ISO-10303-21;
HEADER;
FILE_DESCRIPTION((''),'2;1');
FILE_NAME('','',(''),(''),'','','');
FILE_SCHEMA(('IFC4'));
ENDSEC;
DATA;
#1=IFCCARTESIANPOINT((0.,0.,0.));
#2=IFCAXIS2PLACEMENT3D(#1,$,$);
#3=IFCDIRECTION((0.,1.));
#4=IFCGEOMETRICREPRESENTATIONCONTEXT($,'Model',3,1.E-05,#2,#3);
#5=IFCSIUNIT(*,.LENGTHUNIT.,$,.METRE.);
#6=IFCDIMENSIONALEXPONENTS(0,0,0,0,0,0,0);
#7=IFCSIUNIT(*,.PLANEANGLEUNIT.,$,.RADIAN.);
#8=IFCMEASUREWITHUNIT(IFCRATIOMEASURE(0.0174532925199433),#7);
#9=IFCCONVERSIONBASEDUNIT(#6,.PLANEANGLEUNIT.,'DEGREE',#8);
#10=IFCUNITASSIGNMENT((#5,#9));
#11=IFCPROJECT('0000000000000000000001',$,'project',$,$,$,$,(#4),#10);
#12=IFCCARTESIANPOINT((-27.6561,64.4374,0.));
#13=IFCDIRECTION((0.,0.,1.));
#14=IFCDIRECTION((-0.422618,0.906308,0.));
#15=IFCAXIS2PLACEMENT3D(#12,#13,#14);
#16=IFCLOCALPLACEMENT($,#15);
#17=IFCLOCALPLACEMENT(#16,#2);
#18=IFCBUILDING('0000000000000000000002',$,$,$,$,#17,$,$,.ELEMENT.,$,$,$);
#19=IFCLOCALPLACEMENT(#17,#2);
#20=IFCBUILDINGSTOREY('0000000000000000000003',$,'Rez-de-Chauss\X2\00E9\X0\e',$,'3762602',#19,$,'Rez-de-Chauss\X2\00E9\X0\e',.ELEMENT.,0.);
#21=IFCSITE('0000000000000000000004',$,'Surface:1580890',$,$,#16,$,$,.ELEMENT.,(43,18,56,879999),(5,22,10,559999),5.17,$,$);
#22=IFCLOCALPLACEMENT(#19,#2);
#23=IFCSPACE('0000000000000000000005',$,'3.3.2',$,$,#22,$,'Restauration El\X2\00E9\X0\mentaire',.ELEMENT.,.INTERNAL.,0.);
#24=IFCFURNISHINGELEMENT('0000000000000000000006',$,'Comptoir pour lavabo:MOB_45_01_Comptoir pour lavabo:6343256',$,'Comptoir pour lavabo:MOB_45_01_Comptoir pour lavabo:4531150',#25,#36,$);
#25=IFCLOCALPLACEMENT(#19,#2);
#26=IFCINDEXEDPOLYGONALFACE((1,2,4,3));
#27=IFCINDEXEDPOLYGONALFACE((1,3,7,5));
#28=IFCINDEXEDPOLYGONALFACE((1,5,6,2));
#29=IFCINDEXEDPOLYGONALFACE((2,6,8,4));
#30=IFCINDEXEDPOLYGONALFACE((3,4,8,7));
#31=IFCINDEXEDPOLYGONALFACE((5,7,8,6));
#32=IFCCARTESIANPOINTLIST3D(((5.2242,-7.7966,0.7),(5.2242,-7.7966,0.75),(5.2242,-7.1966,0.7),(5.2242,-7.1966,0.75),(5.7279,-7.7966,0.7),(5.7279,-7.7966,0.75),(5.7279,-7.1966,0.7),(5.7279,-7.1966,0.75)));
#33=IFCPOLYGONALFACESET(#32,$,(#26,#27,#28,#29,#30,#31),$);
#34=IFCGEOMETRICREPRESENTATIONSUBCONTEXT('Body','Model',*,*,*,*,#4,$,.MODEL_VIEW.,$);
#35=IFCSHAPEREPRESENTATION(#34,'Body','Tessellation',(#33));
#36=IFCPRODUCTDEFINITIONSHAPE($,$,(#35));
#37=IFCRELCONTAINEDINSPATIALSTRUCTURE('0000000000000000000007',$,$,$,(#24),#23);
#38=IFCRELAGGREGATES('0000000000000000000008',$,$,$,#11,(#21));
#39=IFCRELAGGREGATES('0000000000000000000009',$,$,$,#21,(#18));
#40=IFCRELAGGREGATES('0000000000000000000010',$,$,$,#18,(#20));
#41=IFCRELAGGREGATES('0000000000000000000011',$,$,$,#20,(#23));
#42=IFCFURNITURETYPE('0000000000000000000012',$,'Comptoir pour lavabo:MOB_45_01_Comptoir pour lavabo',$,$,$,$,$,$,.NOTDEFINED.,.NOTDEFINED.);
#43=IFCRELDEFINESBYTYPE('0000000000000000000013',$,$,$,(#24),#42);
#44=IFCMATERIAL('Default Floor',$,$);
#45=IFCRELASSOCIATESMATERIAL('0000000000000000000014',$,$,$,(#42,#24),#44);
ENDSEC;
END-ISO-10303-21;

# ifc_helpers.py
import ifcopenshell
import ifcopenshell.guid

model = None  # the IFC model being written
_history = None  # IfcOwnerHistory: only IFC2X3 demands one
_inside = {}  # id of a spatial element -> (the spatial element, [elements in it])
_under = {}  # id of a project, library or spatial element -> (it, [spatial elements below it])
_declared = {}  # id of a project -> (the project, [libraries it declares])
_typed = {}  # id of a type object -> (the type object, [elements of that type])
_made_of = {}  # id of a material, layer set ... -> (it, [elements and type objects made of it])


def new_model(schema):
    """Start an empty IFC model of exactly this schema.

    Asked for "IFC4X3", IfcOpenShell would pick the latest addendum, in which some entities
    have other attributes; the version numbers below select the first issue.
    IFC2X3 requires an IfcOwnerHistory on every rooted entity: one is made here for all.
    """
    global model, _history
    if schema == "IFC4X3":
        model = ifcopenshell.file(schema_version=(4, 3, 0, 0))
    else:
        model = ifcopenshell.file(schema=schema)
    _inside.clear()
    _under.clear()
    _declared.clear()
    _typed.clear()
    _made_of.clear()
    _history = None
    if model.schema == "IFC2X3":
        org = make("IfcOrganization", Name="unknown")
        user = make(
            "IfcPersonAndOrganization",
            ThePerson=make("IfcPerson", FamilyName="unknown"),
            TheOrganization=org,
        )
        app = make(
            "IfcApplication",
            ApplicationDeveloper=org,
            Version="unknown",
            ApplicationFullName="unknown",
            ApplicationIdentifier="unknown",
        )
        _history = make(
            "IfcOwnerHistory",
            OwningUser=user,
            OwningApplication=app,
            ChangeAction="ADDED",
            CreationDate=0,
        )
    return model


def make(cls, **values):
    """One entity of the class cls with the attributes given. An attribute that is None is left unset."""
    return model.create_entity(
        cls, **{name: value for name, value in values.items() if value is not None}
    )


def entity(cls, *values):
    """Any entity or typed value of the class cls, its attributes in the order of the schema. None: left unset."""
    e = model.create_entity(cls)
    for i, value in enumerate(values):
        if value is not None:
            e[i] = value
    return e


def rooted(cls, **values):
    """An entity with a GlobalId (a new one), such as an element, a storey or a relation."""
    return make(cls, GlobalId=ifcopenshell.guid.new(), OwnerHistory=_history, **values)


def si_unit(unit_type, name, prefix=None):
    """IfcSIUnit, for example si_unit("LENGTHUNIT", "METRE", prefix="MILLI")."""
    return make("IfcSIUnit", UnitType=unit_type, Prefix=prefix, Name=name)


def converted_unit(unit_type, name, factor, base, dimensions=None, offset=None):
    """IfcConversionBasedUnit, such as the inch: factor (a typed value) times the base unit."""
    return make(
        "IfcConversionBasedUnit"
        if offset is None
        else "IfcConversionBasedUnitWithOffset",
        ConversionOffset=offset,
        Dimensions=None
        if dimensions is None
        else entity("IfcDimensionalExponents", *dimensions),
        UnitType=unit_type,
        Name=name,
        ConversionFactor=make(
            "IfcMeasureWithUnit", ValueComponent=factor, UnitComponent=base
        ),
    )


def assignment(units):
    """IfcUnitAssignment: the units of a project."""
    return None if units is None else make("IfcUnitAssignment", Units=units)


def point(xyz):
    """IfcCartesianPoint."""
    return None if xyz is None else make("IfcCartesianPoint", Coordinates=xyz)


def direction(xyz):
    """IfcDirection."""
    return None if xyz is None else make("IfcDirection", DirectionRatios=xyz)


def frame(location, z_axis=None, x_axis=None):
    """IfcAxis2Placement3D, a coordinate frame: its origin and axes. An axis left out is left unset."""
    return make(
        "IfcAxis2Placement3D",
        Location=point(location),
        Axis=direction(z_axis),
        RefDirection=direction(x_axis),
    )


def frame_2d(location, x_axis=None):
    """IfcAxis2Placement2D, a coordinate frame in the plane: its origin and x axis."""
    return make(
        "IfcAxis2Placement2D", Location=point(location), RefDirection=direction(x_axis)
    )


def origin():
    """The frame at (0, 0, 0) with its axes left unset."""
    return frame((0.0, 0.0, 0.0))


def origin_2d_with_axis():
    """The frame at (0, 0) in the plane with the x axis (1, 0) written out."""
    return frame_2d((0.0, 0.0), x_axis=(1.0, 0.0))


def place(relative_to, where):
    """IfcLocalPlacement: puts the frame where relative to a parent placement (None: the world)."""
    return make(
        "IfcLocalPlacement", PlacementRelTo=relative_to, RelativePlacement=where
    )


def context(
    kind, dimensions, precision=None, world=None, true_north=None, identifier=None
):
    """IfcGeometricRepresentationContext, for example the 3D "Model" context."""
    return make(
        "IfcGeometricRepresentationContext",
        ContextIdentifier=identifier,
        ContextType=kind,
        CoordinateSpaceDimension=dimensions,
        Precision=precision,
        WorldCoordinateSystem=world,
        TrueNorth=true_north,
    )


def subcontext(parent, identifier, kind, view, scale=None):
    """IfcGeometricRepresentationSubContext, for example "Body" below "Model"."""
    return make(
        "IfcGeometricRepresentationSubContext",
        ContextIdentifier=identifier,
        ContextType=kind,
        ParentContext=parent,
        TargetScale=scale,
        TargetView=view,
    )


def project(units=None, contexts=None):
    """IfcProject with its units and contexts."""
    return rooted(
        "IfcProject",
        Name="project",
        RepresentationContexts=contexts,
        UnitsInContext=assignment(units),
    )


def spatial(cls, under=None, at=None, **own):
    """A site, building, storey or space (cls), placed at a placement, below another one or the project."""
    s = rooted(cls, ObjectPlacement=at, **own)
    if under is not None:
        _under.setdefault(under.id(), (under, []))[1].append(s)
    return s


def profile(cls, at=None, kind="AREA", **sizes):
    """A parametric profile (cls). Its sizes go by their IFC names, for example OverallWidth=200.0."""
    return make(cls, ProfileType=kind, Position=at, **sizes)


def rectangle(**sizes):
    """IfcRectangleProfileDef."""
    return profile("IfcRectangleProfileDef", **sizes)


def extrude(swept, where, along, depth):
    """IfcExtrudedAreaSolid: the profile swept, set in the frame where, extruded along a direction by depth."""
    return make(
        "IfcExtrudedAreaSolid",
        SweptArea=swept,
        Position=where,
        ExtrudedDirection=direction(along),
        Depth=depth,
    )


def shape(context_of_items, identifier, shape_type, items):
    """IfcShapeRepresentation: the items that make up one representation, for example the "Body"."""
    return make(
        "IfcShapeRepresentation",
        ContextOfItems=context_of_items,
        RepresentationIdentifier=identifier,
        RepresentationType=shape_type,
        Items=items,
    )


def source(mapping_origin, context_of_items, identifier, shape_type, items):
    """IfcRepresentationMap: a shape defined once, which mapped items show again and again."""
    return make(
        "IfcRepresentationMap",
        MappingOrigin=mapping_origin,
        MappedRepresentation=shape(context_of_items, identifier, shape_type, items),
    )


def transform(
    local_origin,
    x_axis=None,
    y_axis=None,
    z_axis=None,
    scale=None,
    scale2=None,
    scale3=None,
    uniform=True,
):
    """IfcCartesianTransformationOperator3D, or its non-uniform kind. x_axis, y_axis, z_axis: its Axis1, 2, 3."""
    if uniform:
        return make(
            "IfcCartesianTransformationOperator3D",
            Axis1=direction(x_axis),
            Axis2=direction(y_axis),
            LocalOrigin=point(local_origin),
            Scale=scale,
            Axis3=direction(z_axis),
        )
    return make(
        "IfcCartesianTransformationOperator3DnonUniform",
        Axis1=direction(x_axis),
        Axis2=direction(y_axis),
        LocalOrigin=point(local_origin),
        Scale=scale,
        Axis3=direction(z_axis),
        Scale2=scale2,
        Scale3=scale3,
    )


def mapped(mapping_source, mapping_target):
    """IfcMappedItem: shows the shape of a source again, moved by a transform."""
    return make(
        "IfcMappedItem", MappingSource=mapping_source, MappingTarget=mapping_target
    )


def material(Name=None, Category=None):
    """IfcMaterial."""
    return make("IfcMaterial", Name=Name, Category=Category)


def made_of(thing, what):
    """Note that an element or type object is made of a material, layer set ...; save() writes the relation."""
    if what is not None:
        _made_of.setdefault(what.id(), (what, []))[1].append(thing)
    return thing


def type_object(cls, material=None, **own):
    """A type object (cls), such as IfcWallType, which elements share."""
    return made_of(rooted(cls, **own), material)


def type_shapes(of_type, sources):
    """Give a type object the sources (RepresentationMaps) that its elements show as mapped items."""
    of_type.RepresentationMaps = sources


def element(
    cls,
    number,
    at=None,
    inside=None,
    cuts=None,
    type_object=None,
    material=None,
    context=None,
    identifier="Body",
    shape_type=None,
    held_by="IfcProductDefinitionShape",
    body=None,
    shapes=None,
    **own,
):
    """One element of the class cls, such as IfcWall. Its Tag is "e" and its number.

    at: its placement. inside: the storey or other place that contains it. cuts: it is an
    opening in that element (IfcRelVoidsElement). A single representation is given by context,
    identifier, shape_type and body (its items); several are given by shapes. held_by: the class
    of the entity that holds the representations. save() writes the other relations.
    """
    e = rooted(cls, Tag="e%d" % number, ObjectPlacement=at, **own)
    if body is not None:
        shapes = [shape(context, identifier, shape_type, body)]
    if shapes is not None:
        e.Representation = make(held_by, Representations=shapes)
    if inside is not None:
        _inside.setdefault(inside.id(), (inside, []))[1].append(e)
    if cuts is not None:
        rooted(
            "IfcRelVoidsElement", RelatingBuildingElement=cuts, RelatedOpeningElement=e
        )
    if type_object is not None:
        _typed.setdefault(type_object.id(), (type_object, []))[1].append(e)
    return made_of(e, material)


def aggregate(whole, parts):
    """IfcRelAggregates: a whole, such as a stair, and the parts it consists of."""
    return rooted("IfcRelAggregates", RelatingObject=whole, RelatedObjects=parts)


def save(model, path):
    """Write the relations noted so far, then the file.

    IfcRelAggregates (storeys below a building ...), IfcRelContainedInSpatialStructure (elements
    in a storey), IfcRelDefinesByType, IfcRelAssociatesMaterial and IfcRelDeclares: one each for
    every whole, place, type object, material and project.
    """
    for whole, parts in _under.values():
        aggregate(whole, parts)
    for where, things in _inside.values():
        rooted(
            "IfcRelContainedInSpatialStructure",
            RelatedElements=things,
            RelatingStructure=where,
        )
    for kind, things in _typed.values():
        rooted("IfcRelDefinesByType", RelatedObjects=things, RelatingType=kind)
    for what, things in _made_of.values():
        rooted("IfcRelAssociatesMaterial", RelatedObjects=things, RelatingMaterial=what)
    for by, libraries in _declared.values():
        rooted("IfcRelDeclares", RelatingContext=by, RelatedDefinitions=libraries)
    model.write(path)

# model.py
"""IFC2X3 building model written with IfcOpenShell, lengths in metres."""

from ifc_helpers import new_model, entity, si_unit, converted_unit, direction, frame, origin, origin_2d_with_axis, place, context, subcontext, project, spatial, rectangle, extrude, source, transform, mapped, material, type_object, type_shapes, element, save


model = new_model("IFC2X3")

# Units and contexts
model_context = context("Model", 3, precision=1e-05, world=origin(), true_north=direction((0.0, 1.0)))
body_context = subcontext(model_context, "Body", "Model", "MODEL_VIEW")
ifc_project = project(units=[si_unit("LENGTHUNIT", "METRE"), converted_unit("PLANEANGLEUNIT", "DEGREE", entity("IfcRatioMeasure", 0.0174532925199433), si_unit("PLANEANGLEUNIT", "RADIAN"), dimensions=[0, 0, 0, 0, 0, 0, 0])], contexts=[model_context])

# Site, building, storey
site_placement = place(None, frame((-27.6561, 64.4374, 0.0), z_axis=(0.0, 0.0, 1.0), x_axis=(-0.422618, 0.906308, 0.0)))
site = spatial("IfcSite", under=ifc_project, at=site_placement, Name="Surface:1580890", CompositionType="ELEMENT", RefLatitude=(43, 18, 56, 879999), RefLongitude=(5, 22, 10, 559999), RefElevation=5.17)
building_placement = place(site_placement, origin())
building = spatial("IfcBuilding", under=site, at=building_placement, CompositionType="ELEMENT")
storey_placement = place(building_placement, origin())
storey = spatial("IfcBuildingStorey", under=building, at=storey_placement, Name="Rez-de-Chaussée", ObjectType="3762602", LongName="Rez-de-Chaussée", CompositionType="ELEMENT", Elevation=0.0)

# Shared definitions
ifc_material_1 = material(Name="Default Floor")

# Shared definitions
space_1_placement = place(storey_placement, origin())
space_1 = spatial("IfcSpace", under=storey, at=space_1_placement, Name="3.3.2", LongName="Restauration Elémentaire", CompositionType="ELEMENT", InteriorOrExteriorSpace="INTERNAL", ElevationWithFlooring=0.0)

# Furnishing element
furniture_type_1 = type_object("IfcFurnitureType", Name="Comptoir pour lavabo:MOB_45_01_Comptoir pour lavabo", material=ifc_material_1)
shared_shape_1 = source(origin(), body_context, "Body", "SweptSolid", [
    extrude(rectangle(XDim=0.6, YDim=0.5038, at=origin_2d_with_axis()), frame((0.0447, -0.2519, 0.75), z_axis=(0.0, 0.0, 1.0), x_axis=(-1.0, 0.0, 0.0)), (0.0, 0.0, 1.0), 0.05),
])
type_shapes(furniture_type_1, [shared_shape_1])
furnishing_1_placement = place(space_1_placement, frame((5.7279, -7.4519, -0.05), z_axis=(0.0, 0.0, 1.0), x_axis=(0.0, -1.0, 0.0)))
element("IfcFurnishingElement", 1, at=furnishing_1_placement, inside=space_1, type_object=furniture_type_1, material=ifc_material_1, Name="Comptoir pour lavabo:MOB_45_01_Comptoir pour lavabo:6343256", ObjectType="Comptoir pour lavabo:MOB_45_01_Comptoir pour lavabo:4531150", context=body_context, shape_type="MappedRepresentation", body=[
    mapped(shared_shape_1, transform((0.0, 0.0, 0.0), scale=1.0)),
])

save(model, "model.ifc")
